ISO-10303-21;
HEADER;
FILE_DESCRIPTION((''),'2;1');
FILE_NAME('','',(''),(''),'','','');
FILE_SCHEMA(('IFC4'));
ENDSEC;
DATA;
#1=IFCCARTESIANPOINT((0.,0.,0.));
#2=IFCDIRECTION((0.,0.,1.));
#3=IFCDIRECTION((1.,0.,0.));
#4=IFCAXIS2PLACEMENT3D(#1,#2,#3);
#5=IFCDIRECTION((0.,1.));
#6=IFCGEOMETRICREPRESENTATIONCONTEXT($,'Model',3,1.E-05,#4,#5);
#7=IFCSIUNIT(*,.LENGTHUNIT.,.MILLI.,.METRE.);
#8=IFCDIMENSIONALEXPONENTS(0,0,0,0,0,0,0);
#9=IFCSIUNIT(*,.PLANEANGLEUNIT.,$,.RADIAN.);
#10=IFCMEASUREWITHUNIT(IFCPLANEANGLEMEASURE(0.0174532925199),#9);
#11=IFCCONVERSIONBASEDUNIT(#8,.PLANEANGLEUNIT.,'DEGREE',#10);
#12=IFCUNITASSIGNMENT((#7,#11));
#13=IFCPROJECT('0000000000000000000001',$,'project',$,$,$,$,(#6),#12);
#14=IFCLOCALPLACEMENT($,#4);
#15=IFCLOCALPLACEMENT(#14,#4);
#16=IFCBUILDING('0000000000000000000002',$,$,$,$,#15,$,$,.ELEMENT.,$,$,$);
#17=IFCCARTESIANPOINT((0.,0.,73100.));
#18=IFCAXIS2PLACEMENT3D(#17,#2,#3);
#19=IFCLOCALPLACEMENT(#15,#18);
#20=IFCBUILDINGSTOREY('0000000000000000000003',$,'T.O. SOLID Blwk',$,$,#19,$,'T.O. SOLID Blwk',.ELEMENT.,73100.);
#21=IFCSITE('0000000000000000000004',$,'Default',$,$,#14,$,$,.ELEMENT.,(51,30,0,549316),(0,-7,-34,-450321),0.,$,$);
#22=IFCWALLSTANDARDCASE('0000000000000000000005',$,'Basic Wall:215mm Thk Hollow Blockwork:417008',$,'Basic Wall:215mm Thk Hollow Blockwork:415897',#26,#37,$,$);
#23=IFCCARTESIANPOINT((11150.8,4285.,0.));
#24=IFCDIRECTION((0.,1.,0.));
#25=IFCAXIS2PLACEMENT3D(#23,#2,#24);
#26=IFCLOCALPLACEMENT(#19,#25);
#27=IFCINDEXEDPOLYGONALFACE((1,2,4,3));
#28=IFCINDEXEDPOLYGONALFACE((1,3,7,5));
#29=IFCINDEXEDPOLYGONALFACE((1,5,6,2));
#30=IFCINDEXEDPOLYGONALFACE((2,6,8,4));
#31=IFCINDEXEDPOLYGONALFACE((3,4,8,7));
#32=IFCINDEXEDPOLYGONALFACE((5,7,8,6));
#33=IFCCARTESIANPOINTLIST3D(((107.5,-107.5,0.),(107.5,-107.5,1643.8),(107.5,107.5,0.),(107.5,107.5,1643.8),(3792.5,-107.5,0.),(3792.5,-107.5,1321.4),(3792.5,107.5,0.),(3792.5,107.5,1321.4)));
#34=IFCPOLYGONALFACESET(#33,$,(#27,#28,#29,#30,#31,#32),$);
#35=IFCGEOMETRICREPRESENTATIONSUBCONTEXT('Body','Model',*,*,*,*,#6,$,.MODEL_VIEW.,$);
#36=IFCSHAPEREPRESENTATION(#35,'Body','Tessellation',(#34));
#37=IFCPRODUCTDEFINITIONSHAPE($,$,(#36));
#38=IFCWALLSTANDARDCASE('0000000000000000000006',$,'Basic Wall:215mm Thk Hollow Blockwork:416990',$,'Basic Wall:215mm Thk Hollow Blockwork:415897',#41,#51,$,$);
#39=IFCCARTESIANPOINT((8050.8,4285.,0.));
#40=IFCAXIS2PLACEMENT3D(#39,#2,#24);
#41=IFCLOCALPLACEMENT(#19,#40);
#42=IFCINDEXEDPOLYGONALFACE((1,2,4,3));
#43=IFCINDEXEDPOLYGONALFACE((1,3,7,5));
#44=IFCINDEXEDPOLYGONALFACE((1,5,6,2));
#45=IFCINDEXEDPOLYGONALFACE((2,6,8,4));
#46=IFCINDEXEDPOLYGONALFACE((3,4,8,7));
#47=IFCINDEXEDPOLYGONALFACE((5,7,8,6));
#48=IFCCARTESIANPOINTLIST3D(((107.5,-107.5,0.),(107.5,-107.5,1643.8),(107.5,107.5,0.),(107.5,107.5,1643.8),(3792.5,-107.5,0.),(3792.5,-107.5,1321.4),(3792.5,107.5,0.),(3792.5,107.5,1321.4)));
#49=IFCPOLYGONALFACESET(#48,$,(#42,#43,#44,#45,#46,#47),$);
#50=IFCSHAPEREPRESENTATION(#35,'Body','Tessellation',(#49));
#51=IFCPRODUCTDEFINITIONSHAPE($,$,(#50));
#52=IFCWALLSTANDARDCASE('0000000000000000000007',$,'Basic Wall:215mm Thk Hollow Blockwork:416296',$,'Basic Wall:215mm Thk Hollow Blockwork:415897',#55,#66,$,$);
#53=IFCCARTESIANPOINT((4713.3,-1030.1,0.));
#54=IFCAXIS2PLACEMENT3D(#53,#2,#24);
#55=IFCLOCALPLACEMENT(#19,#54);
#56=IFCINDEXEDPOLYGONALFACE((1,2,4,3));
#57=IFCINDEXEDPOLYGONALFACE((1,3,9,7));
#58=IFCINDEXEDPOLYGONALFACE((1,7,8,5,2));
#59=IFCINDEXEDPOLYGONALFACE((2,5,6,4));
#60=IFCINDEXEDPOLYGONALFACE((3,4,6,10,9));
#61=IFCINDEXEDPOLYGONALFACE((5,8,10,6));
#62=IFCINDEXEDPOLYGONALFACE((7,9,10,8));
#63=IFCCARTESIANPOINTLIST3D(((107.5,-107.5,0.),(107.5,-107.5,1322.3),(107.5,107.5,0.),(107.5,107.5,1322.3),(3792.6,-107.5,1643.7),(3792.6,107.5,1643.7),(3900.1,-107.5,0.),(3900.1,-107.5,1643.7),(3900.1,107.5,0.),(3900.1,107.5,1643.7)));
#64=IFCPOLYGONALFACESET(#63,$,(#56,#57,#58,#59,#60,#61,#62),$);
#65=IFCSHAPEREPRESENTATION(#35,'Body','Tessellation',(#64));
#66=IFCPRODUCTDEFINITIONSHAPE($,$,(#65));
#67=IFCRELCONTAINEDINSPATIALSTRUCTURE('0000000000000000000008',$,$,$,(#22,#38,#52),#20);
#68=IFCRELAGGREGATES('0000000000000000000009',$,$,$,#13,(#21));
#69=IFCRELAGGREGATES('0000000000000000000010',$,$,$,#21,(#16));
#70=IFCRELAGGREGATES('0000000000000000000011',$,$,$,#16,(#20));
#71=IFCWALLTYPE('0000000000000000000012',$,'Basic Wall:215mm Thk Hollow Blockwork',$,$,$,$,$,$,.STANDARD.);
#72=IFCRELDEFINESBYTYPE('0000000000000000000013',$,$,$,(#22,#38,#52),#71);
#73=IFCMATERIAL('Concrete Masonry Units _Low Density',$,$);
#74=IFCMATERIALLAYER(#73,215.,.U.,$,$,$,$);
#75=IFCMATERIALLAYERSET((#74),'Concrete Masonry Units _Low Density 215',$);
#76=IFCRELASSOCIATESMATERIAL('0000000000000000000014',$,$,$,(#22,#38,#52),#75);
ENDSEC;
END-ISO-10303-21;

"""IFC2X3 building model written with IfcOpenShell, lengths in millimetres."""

from ifc_helpers import new_model, entity, si_unit, converted_unit, direction, frame, origin_with_axes, place, context, subcontext, project, spatial, polyline, outline, extrude, clip, halfspace, material, layer, layer_set, layer_usage, type_object, element, save


model = new_model("IFC2X3")

# Units and contexts
model_context = context("Model", 3, precision=1e-05, world=origin_with_axes(), true_north=direction((0.0, 1.0)))
body_context = subcontext(model_context, "Body", "Model", "MODEL_VIEW")
ifc_project = project(units=[si_unit("LENGTHUNIT", "METRE", prefix="MILLI"), converted_unit("PLANEANGLEUNIT", "DEGREE", entity("IfcPlaneAngleMeasure", 0.0174532925199), si_unit("PLANEANGLEUNIT", "RADIAN"), dimensions=[0, 0, 0, 0, 0, 0, 0])], contexts=[model_context])

# Site, building, storey
site_placement = place(None, origin_with_axes())
site = spatial("IfcSite", under=ifc_project, at=site_placement, Name="Default", CompositionType="ELEMENT", RefLatitude=(51, 30, 0, 549316), RefLongitude=(0, -7, -34, -450321), RefElevation=0.0)
building_placement = place(site_placement, origin_with_axes())
building = spatial("IfcBuilding", under=site, at=building_placement, CompositionType="ELEMENT")
storey_placement = place(building_placement, frame((0.0, 0.0, 73100.0), z_axis=(0.0, 0.0, 1.0), x_axis=(1.0, 0.0, 0.0)))
storey = spatial("IfcBuildingStorey", under=building, at=storey_placement, Name="T.O. SOLID Blwk", LongName="T.O. SOLID Blwk", CompositionType="ELEMENT", Elevation=73100.0)

# Shared definitions
ifc_material_1 = material(Name="Concrete Masonry Units _Low Density")
ifc_layer = layer(ifc_material_1, 215.0, ventilated="UNKNOWN")
ifc_layer_set = layer_set([ifc_layer], Name="Concrete Masonry Units _Low Density 215")
wall_type = type_object("IfcWallType", Name="Basic Wall:215mm Thk Hollow Blockwork", PredefinedType="STANDARD")

# Walls
ifc_layer_usage_1 = layer_usage(ifc_layer_set, "AXIS2", "POSITIVE", -107.5)
wall_1_placement = place(storey_placement, frame((11150.8, 4285.0, 0.0), z_axis=(0.0, 0.0, 1.0), x_axis=(0.0, 1.0, 0.0)))
element("IfcWallStandardCase", 1, at=wall_1_placement, inside=storey, type_object=wall_type, material=ifc_layer_usage_1, Name="Basic Wall:215mm Thk Hollow Blockwork:417008", ObjectType="Basic Wall:215mm Thk Hollow Blockwork:415897", context=body_context, shape_type="Clipping", body=[
    clip(extrude(outline(polyline([(107.5, -107.5), (3792.5, -107.5), (3792.5, 107.5), (107.5, 107.5), (107.5, -107.5)])), origin_with_axes(), (0.0, 0.0, 1.0), 1643.8), halfspace(frame((143.5, 0.0, 1640.7), z_axis=(-0.087156, 0.0, -0.996195), x_axis=(0.0, 1.0, 0.0)), True)),
])
ifc_layer_usage_2 = layer_usage(ifc_layer_set, "AXIS2", "POSITIVE", -107.5)
wall_2_placement = place(storey_placement, frame((8050.8, 4285.0, 0.0), z_axis=(0.0, 0.0, 1.0), x_axis=(0.0, 1.0, 0.0)))
element("IfcWallStandardCase", 2, at=wall_2_placement, inside=storey, type_object=wall_type, material=ifc_layer_usage_2, Name="Basic Wall:215mm Thk Hollow Blockwork:416990", ObjectType="Basic Wall:215mm Thk Hollow Blockwork:415897", context=body_context, shape_type="Clipping", body=[
    clip(extrude(outline(polyline([(107.5, -107.5), (3792.5, -107.5), (3792.5, 107.5), (107.5, 107.5), (107.5, -107.5)])), origin_with_axes(), (0.0, 0.0, 1.0), 1643.8), halfspace(frame((143.5, 0.0, 1640.7), z_axis=(-0.087156, 0.0, -0.996195), x_axis=(0.0, 1.0, 0.0)), True)),
])
ifc_layer_usage_3 = layer_usage(ifc_layer_set, "AXIS2", "POSITIVE", -107.5)
wall_3_placement = place(storey_placement, frame((4713.3, -1030.1, 0.0), z_axis=(0.0, 0.0, 1.0), x_axis=(0.0, 1.0, 0.0)))
element("IfcWallStandardCase", 3, at=wall_3_placement, inside=storey, type_object=wall_type, material=ifc_layer_usage_3, Name="Basic Wall:215mm Thk Hollow Blockwork:416296", ObjectType="Basic Wall:215mm Thk Hollow Blockwork:415897", context=body_context, shape_type="Clipping", body=[
    clip(extrude(outline(polyline([(107.5, -107.5), (3900.1, -107.5), (3900.1, 107.5), (107.5, 107.5), (107.5, -107.5)])), origin_with_axes(), (0.0, 0.0, 1.0), 1643.7), halfspace(frame((-113.6, 0.0, 1303.0), z_axis=(0.086877, 0.0, -0.996219), x_axis=(0.0, 1.0, 0.0)), True)),
])

save(model, "model.ifc")
